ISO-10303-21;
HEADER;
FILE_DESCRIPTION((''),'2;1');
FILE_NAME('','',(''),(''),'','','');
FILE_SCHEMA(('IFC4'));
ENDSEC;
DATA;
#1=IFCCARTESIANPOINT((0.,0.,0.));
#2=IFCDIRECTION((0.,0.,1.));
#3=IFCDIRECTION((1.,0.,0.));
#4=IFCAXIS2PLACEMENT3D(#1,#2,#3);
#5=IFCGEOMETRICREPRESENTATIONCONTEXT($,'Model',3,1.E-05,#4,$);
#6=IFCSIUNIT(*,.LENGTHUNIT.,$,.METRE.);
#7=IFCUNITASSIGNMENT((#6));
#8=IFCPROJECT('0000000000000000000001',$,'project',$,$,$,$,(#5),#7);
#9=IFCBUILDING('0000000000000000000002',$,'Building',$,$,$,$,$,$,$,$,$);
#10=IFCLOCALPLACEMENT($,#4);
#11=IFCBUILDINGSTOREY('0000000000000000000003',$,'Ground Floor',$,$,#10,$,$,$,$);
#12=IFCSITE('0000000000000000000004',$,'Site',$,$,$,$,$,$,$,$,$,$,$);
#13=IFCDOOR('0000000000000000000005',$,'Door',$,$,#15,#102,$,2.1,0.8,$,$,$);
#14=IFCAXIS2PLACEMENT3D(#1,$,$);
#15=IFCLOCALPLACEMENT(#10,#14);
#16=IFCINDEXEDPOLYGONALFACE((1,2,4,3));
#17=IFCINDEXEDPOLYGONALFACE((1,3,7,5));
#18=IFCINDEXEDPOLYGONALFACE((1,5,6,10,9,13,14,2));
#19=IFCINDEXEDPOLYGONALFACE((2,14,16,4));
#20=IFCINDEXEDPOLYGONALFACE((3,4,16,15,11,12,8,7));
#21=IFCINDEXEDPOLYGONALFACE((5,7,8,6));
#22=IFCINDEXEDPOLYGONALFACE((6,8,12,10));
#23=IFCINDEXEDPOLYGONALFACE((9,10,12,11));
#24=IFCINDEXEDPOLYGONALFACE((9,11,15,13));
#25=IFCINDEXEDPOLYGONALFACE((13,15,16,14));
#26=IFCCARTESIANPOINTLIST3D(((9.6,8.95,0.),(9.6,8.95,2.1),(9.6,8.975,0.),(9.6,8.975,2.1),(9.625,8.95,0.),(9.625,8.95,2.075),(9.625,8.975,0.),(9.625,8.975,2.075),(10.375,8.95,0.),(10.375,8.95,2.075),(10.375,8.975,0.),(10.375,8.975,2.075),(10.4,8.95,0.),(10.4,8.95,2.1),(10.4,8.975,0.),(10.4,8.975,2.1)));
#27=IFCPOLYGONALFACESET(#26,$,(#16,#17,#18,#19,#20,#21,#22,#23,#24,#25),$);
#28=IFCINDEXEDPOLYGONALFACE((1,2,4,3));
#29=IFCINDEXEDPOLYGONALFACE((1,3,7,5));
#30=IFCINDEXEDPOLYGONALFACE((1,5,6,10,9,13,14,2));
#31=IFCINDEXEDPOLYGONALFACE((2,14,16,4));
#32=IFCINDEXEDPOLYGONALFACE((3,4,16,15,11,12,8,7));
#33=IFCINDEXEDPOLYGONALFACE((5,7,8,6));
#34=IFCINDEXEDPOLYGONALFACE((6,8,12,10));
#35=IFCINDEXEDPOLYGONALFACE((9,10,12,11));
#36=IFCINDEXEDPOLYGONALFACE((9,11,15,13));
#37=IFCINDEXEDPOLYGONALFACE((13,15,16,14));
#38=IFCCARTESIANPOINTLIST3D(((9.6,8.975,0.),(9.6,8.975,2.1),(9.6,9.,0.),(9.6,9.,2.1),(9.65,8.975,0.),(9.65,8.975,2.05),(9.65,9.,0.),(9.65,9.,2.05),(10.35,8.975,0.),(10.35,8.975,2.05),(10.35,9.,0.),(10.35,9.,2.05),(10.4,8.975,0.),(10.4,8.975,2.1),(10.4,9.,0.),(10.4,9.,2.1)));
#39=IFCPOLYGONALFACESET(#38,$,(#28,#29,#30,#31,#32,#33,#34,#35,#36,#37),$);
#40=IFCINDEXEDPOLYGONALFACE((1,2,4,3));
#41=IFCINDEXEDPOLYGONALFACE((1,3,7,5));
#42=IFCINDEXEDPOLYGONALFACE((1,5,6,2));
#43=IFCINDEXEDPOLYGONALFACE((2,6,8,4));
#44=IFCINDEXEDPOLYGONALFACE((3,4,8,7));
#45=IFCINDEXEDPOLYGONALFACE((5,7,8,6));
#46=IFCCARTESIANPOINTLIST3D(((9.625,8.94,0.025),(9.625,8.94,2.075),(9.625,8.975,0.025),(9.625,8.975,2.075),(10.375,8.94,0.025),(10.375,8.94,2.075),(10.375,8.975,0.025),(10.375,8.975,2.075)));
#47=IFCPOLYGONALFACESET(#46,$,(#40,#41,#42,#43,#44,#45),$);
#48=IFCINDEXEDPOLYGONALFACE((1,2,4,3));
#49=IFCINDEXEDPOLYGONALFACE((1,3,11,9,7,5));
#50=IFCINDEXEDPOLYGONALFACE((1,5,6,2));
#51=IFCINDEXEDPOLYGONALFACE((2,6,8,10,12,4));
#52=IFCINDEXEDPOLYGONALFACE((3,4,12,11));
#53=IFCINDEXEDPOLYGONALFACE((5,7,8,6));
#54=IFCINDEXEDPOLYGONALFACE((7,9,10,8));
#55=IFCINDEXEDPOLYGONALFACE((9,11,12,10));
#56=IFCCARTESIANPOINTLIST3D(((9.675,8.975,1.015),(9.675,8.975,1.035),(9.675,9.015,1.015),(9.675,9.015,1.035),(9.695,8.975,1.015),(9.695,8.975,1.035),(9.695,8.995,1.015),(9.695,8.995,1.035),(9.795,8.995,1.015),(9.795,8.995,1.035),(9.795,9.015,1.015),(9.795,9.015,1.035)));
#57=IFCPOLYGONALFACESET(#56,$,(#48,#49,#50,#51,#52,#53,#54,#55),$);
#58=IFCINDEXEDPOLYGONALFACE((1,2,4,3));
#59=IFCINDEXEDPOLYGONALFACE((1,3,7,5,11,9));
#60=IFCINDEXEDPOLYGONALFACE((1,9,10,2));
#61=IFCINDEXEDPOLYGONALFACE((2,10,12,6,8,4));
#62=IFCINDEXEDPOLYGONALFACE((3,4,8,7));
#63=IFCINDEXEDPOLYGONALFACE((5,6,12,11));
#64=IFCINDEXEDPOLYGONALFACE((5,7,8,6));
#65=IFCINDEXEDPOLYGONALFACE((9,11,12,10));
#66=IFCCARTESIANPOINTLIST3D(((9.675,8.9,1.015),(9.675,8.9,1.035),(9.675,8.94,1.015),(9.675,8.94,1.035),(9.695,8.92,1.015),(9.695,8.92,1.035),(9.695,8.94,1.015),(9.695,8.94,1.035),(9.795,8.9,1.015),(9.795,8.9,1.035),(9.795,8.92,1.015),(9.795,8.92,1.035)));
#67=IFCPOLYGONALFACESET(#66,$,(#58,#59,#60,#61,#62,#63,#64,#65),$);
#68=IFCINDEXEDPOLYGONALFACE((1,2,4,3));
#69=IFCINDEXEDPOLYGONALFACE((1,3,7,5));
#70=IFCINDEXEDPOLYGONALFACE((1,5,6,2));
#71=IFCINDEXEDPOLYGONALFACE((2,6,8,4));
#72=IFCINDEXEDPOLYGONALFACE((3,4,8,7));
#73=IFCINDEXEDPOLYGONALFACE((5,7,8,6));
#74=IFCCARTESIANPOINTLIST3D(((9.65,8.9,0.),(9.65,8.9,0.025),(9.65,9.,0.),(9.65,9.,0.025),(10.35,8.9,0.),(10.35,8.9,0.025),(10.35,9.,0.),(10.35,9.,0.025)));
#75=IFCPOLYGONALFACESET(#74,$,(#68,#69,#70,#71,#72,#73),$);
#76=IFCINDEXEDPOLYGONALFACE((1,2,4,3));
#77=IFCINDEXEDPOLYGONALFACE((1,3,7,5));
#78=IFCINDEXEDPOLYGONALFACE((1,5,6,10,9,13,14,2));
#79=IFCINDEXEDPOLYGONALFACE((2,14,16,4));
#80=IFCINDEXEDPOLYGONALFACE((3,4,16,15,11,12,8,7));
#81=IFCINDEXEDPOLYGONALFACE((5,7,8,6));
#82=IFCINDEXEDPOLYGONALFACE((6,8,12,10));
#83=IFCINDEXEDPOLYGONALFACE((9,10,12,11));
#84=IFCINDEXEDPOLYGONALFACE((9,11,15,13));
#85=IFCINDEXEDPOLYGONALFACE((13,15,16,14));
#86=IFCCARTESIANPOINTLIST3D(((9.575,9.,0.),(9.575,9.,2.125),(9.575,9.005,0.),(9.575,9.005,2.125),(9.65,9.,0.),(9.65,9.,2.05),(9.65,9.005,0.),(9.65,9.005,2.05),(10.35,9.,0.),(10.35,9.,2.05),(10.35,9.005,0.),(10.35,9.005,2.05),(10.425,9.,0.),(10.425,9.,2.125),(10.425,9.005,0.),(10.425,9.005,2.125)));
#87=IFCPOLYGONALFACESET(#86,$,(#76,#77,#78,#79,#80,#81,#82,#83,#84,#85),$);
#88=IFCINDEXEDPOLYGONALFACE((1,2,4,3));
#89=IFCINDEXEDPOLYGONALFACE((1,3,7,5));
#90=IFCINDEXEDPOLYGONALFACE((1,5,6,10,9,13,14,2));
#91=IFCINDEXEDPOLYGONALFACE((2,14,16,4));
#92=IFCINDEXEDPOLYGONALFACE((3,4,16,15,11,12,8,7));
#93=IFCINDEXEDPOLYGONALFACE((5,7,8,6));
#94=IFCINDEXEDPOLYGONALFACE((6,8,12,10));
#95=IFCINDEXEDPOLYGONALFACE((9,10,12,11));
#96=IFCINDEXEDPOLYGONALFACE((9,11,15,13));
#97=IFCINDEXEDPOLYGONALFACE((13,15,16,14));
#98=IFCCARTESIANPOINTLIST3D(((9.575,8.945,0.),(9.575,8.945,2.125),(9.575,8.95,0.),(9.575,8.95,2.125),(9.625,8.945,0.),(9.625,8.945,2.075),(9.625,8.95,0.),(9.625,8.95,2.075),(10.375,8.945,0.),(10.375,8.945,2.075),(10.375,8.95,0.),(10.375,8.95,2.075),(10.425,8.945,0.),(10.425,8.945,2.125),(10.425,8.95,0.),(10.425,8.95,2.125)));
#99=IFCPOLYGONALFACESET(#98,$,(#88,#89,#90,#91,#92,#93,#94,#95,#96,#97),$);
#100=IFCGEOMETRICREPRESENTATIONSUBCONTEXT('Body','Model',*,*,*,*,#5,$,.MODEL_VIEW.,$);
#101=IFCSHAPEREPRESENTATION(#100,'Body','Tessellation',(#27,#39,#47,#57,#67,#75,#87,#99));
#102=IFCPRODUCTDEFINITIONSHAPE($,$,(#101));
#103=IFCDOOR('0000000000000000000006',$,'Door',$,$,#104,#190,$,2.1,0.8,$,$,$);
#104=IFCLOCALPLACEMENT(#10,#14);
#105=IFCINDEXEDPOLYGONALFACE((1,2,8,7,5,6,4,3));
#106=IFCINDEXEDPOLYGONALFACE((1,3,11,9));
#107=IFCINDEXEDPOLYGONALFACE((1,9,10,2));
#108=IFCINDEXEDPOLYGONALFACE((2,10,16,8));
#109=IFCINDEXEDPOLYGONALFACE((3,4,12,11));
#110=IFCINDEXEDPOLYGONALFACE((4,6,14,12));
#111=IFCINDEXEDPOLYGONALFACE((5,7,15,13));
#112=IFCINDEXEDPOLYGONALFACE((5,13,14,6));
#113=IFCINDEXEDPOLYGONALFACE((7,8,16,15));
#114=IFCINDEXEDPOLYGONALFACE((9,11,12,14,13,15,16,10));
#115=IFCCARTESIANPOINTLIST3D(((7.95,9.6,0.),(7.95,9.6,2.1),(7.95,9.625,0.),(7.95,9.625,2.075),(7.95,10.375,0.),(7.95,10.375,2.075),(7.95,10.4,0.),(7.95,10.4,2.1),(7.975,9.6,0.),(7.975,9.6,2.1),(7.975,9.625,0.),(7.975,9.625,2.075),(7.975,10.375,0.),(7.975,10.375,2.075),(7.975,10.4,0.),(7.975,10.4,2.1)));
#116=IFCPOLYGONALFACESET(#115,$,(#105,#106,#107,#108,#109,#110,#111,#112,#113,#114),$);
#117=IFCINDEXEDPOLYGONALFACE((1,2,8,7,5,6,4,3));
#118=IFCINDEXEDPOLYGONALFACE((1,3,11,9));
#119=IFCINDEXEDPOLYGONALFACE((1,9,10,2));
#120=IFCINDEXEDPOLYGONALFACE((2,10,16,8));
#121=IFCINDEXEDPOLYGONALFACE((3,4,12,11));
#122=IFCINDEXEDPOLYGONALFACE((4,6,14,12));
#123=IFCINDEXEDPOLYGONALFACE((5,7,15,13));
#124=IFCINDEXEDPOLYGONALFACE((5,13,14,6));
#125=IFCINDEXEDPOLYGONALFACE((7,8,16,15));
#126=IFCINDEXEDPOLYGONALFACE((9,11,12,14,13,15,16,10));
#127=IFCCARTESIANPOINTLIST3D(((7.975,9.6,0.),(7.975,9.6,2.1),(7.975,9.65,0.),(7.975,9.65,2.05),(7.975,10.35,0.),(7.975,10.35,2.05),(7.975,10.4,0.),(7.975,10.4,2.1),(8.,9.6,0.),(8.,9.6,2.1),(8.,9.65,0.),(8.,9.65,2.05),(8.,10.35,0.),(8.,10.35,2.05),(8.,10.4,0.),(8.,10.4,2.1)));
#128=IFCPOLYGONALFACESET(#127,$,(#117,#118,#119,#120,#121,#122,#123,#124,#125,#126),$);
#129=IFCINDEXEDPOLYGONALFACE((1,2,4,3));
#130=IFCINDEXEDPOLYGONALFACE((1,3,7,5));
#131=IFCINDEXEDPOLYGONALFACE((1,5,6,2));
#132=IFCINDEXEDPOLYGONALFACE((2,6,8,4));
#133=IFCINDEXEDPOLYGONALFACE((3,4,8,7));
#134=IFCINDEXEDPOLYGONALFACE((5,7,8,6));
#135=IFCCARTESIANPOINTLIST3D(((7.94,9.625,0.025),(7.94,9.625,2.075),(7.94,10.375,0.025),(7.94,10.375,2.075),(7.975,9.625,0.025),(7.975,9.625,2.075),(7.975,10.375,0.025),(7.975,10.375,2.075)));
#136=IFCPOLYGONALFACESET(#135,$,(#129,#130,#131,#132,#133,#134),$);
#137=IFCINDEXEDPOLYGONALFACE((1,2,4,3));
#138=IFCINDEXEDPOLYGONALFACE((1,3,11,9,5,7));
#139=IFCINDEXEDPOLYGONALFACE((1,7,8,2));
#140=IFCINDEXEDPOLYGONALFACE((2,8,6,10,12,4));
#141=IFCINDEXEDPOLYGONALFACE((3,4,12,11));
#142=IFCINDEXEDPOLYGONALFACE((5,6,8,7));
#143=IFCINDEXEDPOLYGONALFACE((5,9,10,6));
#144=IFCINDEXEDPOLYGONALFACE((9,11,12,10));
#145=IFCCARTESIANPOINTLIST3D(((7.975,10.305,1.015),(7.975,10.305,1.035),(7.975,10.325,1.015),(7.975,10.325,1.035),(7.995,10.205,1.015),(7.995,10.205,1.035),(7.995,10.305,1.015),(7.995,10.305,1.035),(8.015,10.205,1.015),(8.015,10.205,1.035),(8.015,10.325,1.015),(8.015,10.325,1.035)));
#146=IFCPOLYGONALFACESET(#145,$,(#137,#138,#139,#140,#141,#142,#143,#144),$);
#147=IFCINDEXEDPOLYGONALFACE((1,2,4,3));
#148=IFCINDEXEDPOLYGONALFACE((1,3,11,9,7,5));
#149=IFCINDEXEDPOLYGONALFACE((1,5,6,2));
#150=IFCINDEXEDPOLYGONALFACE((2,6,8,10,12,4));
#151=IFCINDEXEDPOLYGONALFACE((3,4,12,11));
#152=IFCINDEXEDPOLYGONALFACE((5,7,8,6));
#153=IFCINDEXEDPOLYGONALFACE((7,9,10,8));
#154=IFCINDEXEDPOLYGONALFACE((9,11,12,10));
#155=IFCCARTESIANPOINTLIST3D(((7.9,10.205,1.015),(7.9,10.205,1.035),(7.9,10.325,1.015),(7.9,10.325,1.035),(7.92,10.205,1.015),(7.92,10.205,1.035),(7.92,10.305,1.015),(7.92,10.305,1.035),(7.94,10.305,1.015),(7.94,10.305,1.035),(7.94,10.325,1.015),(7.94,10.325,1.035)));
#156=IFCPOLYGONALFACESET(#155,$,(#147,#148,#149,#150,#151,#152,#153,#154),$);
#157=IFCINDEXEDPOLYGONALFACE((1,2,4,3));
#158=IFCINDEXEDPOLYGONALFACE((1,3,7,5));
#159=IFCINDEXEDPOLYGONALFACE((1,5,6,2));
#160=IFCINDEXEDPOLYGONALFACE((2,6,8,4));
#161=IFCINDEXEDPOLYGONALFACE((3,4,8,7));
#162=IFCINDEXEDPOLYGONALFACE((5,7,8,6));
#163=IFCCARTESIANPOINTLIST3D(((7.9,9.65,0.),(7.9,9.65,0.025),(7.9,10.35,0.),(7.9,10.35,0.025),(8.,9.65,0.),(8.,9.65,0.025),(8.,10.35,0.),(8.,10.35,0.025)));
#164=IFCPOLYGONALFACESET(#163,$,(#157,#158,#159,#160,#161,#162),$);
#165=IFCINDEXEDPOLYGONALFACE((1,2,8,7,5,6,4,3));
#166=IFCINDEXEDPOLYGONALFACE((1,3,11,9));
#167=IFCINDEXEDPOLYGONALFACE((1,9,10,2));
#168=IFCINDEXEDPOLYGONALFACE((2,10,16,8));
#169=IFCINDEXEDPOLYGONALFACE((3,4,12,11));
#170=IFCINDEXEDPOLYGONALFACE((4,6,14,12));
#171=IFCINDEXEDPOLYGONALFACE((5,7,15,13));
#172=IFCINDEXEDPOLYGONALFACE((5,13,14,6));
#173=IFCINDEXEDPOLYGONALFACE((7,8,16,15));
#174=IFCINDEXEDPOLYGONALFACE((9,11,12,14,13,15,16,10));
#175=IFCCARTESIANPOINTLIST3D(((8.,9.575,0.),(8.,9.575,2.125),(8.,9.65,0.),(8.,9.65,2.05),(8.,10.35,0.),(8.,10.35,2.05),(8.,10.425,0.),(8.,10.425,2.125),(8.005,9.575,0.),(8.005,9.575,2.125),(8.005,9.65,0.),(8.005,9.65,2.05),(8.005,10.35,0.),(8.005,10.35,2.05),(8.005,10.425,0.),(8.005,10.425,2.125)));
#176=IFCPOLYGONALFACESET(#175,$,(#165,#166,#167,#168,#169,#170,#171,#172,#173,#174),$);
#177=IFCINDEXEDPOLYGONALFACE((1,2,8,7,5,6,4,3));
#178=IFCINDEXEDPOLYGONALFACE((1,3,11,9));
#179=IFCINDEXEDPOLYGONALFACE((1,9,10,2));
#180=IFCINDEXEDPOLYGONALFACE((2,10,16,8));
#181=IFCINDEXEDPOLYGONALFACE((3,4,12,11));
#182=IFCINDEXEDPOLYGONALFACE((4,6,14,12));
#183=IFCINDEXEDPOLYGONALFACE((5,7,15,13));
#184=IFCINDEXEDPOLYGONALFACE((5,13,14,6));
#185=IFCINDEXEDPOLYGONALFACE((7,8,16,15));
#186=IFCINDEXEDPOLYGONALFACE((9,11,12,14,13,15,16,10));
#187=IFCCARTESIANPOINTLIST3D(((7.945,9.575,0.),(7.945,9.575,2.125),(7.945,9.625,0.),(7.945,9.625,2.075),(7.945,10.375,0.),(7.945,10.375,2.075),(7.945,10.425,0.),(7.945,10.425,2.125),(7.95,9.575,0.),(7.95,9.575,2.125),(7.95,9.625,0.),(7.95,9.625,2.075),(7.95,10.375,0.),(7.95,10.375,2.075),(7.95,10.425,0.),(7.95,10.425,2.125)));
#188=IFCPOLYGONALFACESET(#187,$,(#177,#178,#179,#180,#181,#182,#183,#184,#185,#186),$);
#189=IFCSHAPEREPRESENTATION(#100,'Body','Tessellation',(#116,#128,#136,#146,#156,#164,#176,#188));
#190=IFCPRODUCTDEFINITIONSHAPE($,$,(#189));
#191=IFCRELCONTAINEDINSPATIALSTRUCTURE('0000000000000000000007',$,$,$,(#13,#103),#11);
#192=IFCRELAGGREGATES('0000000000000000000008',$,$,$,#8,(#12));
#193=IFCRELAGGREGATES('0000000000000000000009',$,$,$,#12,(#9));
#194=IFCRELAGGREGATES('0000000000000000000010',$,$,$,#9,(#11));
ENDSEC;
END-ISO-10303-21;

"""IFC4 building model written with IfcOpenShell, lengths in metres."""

from ifc_helpers import new_model, si_unit, frame, origin_with_axes, place, context, subcontext, project, spatial, line, indexed_curve, outline, extrude, element, save


model = new_model("IFC4")

# Units and contexts
model_context = context("Model", 3, precision=1e-05, world=origin_with_axes())
body_context = subcontext(model_context, "Body", "Model", "MODEL_VIEW")
ifc_project = project(units=[si_unit("LENGTHUNIT", "METRE")], contexts=[model_context])

# Site, building, storey
site = spatial("IfcSite", under=ifc_project, Name="Site")
building = spatial("IfcBuilding", under=site, Name="Building")
storey_placement = place(None, origin_with_axes())
storey = spatial("IfcBuildingStorey", under=building, at=storey_placement, Name="Ground Floor")

# Doors
door_1_placement = place(storey_placement, frame((10.4, 9.0, 0.0), z_axis=(0.0, 0.0, 1.0), x_axis=(-1.0, 0.0, 0.0)))
element("IfcDoor", 1, at=door_1_placement, inside=storey, Name="Door", OverallHeight=2.1, OverallWidth=0.8, context=body_context, shape_type="SweptSolid", body=[
    extrude(outline(indexed_curve([(0.0, 0.0), (0.0, 2.1), (0.8, 2.1), (0.8, 0.0), (0.775, 0.0), (0.775, 2.075), (0.025, 2.075), (0.025, 0.0)], segments=[line(1, 2, 3, 4, 5, 6, 7, 8, 1)])), frame((0.0, 0.025, 0.0), z_axis=(0.0, -1.0, 0.0), x_axis=(1.0, 0.0, 0.0)), (0.0, 0.0, -1.0), 0.025),
    extrude(outline(indexed_curve([(0.0, 0.0), (0.0, 2.1), (0.8, 2.1), (0.8, 0.0), (0.75, 0.0), (0.75, 2.05), (0.05, 2.05), (0.05, 0.0)], segments=[line(1, 2, 3, 4, 5, 6, 7, 8, 1)])), frame((0.0, 0.0, 0.0), z_axis=(0.0, -1.0, 0.0), x_axis=(1.0, 0.0, 0.0)), (0.0, 0.0, -1.0), 0.025),
    extrude(outline(indexed_curve([(0.0, 0.0), (0.75, 0.0), (0.75, 0.035), (0.0, 0.035)], segments=[line(1, 2, 3, 4, 1)])), frame((0.025, 0.025, 0.025), z_axis=(0.0, 0.0, 1.0), x_axis=(1.0, 0.0, 0.0)), (0.0, 0.0, 1.0), 2.05),
    extrude(outline(indexed_curve([(0.0, 0.0), (0.0, -0.04), (-0.12, -0.04), (-0.12, -0.02), (-0.02, -0.02), (-0.02, 0.0)], segments=[line(1, 2, 3, 4, 5, 6, 1)])), frame((0.725, 0.025, 1.015), z_axis=(0.0, 0.0, 1.0), x_axis=(1.0, 0.0, 0.0)), (0.0, 0.0, 1.0), 0.02),
    extrude(outline(indexed_curve([(0.0, 0.0), (0.0, 0.04), (-0.12, 0.04), (-0.12, 0.02), (-0.02, 0.02), (-0.02, 0.0)], segments=[line(1, 2, 3, 4, 5, 6, 1)])), frame((0.725, 0.06, 1.015), z_axis=(0.0, 0.0, 1.0), x_axis=(1.0, 0.0, 0.0)), (0.0, 0.0, 1.0), 0.02),
    extrude(outline(indexed_curve([(0.0, 0.0), (0.7, 0.0), (0.7, 0.1), (0.0, 0.1)], segments=[line(1, 2, 3, 4, 1)])), frame((0.05, 0.0, 0.0), z_axis=(0.0, 0.0, 1.0), x_axis=(1.0, 0.0, 0.0)), (0.0, 0.0, 1.0), 0.025),
    extrude(outline(indexed_curve([(0.0, 0.0), (0.0, 2.125), (0.85, 2.125), (0.85, 0.0), (0.775, 0.0), (0.775, 2.05), (0.075, 2.05), (0.075, 0.0)], segments=[line(1, 2, 3, 4, 5, 6, 7, 8, 1)])), frame((-0.025, -0.005, 0.0), z_axis=(0.0, -1.0, 0.0), x_axis=(1.0, 0.0, 0.0)), (0.0, 0.0, -1.0), 0.005),
    extrude(outline(indexed_curve([(0.0, 0.0), (0.0, 2.125), (0.85, 2.125), (0.85, 0.0), (0.8, 0.0), (0.8, 2.075), (0.05, 2.075), (0.05, 0.0)], segments=[line(1, 2, 3, 4, 5, 6, 7, 8, 1)])), frame((-0.025, 0.05, 0.0), z_axis=(0.0, -1.0, 0.0), x_axis=(1.0, 0.0, 0.0)), (0.0, 0.0, -1.0), 0.005),
])
door_2_placement = place(storey_placement, frame((8.0, 9.6, 0.0), z_axis=(0.0, 0.0, 1.0), x_axis=(0.0, 1.0, 0.0)))
element("IfcDoor", 2, at=door_2_placement, inside=storey, Name="Door", OverallHeight=2.1, OverallWidth=0.8, context=body_context, shape_type="SweptSolid", body=[
    extrude(outline(indexed_curve([(0.0, 0.0), (0.0, 2.1), (0.8, 2.1), (0.8, 0.0), (0.775, 0.0), (0.775, 2.075), (0.025, 2.075), (0.025, 0.0)], segments=[line(1, 2, 3, 4, 5, 6, 7, 8, 1)])), frame((0.0, 0.025, 0.0), z_axis=(0.0, -1.0, 0.0), x_axis=(1.0, 0.0, 0.0)), (0.0, 0.0, -1.0), 0.025),
    extrude(outline(indexed_curve([(0.0, 0.0), (0.0, 2.1), (0.8, 2.1), (0.8, 0.0), (0.75, 0.0), (0.75, 2.05), (0.05, 2.05), (0.05, 0.0)], segments=[line(1, 2, 3, 4, 5, 6, 7, 8, 1)])), frame((0.0, 0.0, 0.0), z_axis=(0.0, -1.0, 0.0), x_axis=(1.0, 0.0, 0.0)), (0.0, 0.0, -1.0), 0.025),
    extrude(outline(indexed_curve([(0.0, 0.0), (0.75, 0.0), (0.75, 0.035), (0.0, 0.035)], segments=[line(1, 2, 3, 4, 1)])), frame((0.025, 0.025, 0.025), z_axis=(0.0, 0.0, 1.0), x_axis=(1.0, 0.0, 0.0)), (0.0, 0.0, 1.0), 2.05),
    extrude(outline(indexed_curve([(0.0, 0.0), (0.0, -0.04), (-0.12, -0.04), (-0.12, -0.02), (-0.02, -0.02), (-0.02, 0.0)], segments=[line(1, 2, 3, 4, 5, 6, 1)])), frame((0.725, 0.025, 1.015), z_axis=(0.0, 0.0, 1.0), x_axis=(1.0, 0.0, 0.0)), (0.0, 0.0, 1.0), 0.02),
    extrude(outline(indexed_curve([(0.0, 0.0), (0.0, 0.04), (-0.12, 0.04), (-0.12, 0.02), (-0.02, 0.02), (-0.02, 0.0)], segments=[line(1, 2, 3, 4, 5, 6, 1)])), frame((0.725, 0.06, 1.015), z_axis=(0.0, 0.0, 1.0), x_axis=(1.0, 0.0, 0.0)), (0.0, 0.0, 1.0), 0.02),
    extrude(outline(indexed_curve([(0.0, 0.0), (0.7, 0.0), (0.7, 0.1), (0.0, 0.1)], segments=[line(1, 2, 3, 4, 1)])), frame((0.05, 0.0, 0.0), z_axis=(0.0, 0.0, 1.0), x_axis=(1.0, 0.0, 0.0)), (0.0, 0.0, 1.0), 0.025),
    extrude(outline(indexed_curve([(0.0, 0.0), (0.0, 2.125), (0.85, 2.125), (0.85, 0.0), (0.775, 0.0), (0.775, 2.05), (0.075, 2.05), (0.075, 0.0)], segments=[line(1, 2, 3, 4, 5, 6, 7, 8, 1)])), frame((-0.025, -0.005, 0.0), z_axis=(0.0, -1.0, 0.0), x_axis=(1.0, 0.0, 0.0)), (0.0, 0.0, -1.0), 0.005),
    extrude(outline(indexed_curve([(0.0, 0.0), (0.0, 2.125), (0.85, 2.125), (0.85, 0.0), (0.8, 0.0), (0.8, 2.075), (0.05, 2.075), (0.05, 0.0)], segments=[line(1, 2, 3, 4, 5, 6, 7, 8, 1)])), frame((-0.025, 0.05, 0.0), z_axis=(0.0, -1.0, 0.0), x_axis=(1.0, 0.0, 0.0)), (0.0, 0.0, -1.0), 0.005),
])

save(model, "model.ifc")
